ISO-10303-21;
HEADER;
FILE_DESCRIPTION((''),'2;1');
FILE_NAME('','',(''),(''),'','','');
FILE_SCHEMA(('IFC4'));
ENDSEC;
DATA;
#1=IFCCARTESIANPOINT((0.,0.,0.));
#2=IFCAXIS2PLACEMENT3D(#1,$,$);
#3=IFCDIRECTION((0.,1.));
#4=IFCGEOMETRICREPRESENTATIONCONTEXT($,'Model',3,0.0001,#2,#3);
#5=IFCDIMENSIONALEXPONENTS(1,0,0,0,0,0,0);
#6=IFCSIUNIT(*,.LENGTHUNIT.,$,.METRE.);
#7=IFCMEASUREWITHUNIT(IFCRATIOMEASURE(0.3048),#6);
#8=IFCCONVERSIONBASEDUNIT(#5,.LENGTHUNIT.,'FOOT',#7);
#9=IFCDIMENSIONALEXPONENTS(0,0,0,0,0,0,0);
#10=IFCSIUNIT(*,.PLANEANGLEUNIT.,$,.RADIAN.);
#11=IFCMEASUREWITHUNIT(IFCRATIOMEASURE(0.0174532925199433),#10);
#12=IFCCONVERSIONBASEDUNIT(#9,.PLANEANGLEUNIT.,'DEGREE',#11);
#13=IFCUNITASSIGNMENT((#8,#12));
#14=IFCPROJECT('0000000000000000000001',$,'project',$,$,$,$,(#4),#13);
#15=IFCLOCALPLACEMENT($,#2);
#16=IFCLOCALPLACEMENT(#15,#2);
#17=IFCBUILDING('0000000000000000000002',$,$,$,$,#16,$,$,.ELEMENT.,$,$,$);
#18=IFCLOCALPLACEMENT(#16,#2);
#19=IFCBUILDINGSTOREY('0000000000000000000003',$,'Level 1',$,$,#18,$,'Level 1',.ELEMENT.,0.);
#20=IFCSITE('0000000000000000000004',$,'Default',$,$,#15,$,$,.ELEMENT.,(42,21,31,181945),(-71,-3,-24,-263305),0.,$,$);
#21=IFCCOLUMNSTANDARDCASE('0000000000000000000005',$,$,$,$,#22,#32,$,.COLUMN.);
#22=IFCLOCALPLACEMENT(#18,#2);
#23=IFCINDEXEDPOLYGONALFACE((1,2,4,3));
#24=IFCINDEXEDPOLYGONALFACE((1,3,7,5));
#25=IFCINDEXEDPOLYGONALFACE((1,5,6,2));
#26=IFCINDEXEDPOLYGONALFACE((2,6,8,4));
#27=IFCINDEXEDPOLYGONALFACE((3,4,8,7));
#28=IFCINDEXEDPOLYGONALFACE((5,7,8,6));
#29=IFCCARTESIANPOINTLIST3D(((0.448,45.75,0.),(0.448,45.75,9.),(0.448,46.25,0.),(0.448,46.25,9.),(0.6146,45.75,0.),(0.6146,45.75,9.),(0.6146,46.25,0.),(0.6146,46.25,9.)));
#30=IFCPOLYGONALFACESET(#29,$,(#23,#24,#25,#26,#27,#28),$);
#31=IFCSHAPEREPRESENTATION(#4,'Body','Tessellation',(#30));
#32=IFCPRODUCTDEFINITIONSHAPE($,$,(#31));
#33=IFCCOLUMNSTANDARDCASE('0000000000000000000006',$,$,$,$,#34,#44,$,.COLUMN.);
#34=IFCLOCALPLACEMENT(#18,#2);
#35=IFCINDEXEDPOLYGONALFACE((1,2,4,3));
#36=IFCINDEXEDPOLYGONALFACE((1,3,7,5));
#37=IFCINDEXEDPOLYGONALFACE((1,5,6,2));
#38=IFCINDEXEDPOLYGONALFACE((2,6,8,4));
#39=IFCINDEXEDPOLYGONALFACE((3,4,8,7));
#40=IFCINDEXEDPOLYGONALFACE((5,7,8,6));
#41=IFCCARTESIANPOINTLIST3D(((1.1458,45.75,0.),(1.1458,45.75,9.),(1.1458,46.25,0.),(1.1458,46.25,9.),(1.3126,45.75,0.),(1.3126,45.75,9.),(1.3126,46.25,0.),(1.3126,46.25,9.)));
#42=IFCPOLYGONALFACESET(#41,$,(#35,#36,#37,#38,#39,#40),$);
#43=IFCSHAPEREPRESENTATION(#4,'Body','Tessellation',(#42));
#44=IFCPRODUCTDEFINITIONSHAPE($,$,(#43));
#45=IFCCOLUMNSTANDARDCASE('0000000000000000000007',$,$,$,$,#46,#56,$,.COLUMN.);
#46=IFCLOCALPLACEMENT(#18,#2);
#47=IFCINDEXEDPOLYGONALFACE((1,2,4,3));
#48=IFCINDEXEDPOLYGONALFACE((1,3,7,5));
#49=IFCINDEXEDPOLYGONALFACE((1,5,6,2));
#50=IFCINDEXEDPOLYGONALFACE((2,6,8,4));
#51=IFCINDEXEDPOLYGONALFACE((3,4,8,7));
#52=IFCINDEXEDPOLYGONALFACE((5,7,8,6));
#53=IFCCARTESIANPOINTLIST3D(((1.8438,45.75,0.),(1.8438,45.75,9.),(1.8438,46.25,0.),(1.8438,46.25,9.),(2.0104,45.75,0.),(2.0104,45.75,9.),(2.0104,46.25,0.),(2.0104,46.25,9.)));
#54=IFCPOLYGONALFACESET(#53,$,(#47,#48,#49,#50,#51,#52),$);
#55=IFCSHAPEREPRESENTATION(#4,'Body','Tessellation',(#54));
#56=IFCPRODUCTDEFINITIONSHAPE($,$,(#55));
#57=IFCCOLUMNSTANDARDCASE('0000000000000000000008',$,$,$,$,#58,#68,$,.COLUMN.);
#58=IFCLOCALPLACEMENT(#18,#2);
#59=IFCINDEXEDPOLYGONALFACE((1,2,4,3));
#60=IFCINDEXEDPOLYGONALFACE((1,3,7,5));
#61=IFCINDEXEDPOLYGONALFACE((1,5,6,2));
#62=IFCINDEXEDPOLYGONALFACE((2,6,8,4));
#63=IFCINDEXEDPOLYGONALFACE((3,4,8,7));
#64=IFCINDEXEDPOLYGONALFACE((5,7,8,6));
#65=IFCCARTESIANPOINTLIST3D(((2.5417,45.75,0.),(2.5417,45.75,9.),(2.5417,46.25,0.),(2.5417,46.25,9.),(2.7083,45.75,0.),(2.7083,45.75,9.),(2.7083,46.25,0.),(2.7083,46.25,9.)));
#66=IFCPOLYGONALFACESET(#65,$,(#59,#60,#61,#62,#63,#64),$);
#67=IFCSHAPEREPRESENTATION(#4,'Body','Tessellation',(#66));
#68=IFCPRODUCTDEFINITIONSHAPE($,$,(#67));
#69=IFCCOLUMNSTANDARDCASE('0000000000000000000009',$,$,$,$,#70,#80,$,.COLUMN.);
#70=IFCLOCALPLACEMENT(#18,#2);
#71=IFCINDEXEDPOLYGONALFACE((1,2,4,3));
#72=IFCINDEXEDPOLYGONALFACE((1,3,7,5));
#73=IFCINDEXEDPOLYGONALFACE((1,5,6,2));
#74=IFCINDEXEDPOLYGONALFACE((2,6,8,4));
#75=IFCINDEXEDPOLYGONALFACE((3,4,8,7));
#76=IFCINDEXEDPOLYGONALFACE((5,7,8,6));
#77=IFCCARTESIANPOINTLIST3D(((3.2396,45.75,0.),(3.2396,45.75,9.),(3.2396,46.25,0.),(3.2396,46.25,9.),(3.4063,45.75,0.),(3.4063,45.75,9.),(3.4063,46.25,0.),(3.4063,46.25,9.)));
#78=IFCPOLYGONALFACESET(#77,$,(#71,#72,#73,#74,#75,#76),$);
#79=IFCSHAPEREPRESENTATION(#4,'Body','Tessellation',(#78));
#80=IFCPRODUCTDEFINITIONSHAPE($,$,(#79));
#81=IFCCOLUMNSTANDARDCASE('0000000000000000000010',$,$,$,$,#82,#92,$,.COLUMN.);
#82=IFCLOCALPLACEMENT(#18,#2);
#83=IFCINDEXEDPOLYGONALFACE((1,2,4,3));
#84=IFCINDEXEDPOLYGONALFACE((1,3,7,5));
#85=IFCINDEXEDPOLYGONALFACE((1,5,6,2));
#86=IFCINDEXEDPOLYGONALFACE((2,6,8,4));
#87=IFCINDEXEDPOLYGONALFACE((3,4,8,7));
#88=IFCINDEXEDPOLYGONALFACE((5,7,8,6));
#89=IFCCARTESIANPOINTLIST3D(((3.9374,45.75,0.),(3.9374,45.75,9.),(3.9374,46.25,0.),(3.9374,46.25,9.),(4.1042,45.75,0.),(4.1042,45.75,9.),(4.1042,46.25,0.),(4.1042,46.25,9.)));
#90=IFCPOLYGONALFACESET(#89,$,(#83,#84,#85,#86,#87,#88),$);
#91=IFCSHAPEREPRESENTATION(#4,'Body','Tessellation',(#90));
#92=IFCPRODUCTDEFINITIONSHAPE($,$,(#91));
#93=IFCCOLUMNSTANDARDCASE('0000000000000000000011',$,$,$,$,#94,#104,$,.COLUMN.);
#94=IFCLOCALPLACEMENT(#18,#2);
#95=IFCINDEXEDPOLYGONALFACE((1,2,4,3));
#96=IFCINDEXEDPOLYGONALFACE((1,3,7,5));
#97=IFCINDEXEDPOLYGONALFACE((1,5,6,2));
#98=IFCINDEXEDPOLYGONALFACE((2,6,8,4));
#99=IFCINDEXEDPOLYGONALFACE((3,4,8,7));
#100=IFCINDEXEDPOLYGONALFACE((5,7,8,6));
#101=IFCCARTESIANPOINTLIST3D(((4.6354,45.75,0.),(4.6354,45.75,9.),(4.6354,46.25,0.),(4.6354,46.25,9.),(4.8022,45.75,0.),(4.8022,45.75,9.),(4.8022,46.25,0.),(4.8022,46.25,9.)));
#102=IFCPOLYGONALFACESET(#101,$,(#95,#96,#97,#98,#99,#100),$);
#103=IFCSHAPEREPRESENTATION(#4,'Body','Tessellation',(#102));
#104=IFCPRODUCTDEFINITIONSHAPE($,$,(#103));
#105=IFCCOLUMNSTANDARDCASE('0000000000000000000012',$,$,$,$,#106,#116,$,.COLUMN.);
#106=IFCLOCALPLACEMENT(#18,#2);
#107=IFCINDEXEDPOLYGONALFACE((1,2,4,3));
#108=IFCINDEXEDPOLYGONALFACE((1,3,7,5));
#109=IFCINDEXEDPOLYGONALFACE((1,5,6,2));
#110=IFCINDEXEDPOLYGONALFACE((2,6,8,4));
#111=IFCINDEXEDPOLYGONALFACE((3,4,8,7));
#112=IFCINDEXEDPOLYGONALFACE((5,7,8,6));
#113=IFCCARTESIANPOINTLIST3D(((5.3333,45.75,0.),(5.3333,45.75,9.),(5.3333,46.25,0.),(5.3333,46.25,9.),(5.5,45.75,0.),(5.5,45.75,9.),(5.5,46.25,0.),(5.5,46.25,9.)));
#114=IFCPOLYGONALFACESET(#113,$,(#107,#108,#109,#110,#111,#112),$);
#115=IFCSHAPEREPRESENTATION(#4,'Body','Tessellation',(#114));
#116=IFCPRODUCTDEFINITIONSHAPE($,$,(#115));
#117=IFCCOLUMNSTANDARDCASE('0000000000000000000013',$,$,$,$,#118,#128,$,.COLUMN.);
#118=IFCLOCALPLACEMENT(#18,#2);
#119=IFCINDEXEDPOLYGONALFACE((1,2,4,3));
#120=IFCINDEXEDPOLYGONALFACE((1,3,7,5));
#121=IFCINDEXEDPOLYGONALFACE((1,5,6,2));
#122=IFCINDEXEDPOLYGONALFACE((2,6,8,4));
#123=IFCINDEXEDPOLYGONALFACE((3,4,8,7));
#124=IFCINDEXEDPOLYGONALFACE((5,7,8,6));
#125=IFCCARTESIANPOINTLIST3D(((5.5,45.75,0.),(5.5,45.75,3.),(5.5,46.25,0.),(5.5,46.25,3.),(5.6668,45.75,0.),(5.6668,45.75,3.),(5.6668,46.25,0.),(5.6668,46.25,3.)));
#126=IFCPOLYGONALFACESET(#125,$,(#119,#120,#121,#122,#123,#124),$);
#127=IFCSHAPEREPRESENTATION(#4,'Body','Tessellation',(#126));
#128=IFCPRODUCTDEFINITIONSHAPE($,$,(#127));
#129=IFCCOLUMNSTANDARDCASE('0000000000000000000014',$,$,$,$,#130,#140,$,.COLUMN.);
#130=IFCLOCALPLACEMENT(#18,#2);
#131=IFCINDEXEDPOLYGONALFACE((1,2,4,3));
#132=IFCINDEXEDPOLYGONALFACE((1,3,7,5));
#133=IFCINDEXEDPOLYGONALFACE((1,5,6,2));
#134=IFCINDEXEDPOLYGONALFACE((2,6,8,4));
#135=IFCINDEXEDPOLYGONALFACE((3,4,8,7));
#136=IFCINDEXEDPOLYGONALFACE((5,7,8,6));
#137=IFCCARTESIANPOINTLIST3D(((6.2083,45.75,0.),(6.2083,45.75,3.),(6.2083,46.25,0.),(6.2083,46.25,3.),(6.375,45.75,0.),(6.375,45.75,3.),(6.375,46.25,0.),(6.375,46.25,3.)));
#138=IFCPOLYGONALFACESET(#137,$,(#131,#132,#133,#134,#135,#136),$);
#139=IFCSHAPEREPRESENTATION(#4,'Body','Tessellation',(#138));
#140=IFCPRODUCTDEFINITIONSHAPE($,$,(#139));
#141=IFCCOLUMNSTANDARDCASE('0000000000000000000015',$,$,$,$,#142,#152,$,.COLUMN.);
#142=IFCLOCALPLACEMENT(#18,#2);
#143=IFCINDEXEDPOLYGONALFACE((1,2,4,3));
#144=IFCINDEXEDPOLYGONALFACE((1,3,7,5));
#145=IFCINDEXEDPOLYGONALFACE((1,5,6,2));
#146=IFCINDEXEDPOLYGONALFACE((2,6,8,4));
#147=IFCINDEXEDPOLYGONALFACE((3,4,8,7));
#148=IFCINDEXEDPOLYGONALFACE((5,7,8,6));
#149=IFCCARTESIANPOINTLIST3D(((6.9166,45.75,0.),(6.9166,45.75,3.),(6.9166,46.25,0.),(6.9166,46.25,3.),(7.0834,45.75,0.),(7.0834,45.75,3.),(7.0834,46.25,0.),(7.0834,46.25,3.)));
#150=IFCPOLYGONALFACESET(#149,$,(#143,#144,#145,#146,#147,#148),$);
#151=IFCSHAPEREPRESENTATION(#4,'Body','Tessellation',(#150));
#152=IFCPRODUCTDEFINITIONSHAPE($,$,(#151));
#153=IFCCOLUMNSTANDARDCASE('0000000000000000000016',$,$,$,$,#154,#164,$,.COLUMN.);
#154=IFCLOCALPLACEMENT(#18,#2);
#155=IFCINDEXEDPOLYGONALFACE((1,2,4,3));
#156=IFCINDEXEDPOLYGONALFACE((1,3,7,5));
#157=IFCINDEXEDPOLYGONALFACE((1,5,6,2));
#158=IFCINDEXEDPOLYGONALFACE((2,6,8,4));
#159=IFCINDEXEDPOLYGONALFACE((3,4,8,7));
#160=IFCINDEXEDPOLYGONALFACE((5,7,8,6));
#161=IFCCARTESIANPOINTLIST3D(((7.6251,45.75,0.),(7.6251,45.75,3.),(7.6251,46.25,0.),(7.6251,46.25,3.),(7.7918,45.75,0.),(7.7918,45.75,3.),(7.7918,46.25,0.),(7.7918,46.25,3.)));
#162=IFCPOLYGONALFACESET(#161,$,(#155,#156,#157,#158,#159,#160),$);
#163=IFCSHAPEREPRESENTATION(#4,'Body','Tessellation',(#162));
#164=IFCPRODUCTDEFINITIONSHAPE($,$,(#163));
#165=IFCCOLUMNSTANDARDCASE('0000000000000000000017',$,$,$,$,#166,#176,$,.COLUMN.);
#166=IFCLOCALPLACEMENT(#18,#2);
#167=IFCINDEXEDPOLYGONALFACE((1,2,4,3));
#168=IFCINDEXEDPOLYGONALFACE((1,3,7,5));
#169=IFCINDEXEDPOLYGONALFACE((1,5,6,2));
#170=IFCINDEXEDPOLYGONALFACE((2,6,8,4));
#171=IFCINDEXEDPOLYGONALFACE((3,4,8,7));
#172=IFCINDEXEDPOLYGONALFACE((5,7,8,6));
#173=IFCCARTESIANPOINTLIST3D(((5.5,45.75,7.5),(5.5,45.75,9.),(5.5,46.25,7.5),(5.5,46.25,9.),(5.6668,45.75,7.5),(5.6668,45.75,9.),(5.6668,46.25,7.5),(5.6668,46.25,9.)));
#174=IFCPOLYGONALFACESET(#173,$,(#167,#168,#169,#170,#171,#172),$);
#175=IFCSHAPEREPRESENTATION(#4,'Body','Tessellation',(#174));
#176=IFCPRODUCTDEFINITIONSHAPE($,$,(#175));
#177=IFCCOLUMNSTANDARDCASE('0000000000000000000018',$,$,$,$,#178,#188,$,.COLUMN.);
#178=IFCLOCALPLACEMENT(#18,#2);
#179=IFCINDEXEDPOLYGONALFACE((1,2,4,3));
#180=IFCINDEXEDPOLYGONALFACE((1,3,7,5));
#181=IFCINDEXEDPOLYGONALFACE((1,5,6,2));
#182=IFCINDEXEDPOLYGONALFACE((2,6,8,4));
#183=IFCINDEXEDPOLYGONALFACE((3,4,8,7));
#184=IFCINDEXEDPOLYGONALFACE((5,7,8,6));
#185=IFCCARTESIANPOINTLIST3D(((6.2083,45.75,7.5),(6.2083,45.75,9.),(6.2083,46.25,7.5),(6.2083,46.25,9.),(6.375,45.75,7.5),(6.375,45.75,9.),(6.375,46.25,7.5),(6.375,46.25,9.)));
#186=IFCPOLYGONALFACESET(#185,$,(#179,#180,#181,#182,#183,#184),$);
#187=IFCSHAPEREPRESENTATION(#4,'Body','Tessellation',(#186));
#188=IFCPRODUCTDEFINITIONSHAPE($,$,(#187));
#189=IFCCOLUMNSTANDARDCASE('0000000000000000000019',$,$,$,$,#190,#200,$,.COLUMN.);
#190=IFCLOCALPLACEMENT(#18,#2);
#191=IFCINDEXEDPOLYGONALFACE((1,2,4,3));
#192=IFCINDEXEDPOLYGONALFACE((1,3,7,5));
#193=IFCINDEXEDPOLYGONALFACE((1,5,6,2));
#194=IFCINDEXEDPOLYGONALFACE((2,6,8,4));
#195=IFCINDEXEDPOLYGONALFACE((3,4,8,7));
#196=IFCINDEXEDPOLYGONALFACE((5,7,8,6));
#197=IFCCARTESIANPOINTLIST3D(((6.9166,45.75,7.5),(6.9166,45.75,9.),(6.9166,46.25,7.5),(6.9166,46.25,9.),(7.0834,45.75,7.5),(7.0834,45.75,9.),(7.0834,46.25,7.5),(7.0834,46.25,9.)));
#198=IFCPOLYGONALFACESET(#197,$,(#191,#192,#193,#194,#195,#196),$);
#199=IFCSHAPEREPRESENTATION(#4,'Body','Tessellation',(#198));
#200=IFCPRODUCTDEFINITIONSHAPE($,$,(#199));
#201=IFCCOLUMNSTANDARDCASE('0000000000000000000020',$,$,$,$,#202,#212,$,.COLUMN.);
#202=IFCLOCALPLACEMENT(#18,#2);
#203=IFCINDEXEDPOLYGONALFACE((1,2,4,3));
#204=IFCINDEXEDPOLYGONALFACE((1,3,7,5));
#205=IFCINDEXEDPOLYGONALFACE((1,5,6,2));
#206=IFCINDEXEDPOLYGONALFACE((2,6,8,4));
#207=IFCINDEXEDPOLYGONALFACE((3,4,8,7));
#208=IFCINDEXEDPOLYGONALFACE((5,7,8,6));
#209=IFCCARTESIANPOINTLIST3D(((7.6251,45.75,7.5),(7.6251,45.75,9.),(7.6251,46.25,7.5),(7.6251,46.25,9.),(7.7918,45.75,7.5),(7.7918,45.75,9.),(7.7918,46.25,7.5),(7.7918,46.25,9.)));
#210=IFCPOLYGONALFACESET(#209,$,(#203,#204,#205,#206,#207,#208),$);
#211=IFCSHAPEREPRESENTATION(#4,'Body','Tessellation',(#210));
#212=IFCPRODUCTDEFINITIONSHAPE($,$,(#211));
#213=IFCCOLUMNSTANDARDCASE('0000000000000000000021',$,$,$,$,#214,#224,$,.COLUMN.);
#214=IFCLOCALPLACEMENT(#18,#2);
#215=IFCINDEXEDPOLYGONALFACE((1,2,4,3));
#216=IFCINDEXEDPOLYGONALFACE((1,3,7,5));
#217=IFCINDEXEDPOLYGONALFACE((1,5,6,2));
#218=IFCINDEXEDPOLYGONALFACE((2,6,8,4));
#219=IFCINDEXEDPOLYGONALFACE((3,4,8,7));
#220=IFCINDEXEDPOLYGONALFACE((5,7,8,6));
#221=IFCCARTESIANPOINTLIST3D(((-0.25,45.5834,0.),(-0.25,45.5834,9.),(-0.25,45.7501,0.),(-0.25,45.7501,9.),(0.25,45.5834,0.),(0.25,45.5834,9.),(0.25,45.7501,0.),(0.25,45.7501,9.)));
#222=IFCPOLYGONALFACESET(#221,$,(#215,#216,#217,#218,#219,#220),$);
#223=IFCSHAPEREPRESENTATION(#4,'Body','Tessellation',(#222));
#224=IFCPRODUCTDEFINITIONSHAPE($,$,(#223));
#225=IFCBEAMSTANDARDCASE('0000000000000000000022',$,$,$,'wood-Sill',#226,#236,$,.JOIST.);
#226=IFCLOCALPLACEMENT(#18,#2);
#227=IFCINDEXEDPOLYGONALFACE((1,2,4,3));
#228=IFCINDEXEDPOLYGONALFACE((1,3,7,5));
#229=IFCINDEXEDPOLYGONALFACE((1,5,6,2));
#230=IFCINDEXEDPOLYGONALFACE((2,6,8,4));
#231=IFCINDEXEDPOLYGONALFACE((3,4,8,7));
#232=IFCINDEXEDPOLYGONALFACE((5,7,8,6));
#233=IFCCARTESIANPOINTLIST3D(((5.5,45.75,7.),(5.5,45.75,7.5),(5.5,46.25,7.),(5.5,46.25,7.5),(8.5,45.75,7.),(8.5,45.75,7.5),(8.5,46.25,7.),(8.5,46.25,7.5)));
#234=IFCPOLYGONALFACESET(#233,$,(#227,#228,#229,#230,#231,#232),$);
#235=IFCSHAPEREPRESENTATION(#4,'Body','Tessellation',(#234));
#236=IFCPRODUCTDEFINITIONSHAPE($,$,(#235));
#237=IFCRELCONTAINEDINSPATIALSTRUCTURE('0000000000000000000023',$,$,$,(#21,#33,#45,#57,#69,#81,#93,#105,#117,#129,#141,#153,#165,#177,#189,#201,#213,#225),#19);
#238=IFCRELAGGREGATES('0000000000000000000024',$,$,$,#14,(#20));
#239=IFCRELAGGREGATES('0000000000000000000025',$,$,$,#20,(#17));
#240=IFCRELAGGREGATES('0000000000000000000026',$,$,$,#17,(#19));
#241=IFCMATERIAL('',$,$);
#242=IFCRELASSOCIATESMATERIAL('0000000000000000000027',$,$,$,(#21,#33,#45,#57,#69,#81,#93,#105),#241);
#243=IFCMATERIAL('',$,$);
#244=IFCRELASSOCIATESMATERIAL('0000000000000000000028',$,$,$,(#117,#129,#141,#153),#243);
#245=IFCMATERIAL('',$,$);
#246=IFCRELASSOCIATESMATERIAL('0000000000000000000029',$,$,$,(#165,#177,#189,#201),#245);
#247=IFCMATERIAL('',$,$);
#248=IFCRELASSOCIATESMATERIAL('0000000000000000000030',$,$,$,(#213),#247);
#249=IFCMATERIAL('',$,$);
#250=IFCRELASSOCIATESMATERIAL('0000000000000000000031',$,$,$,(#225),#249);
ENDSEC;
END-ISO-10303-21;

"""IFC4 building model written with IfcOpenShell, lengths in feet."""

from ifc_helpers import new_model, entity, si_unit, converted_unit, direction, frame, origin, place, context, project, spatial, rectangle, extrude, material, element, save


model = new_model("IFC4")

# Units and contexts
model_context = context("Model", 3, precision=0.0001, world=origin(), true_north=direction((0.0, 1.0)))
ifc_project = project(units=[converted_unit("LENGTHUNIT", "FOOT", entity("IfcRatioMeasure", 0.3048), si_unit("LENGTHUNIT", "METRE"), dimensions=[1, 0, 0, 0, 0, 0, 0]), converted_unit("PLANEANGLEUNIT", "DEGREE", entity("IfcRatioMeasure", 0.0174532925199433), si_unit("PLANEANGLEUNIT", "RADIAN"), dimensions=[0, 0, 0, 0, 0, 0, 0])], contexts=[model_context])

# Site, building, storey
site_placement = place(None, origin())
site = spatial("IfcSite", under=ifc_project, at=site_placement, Name="Default", CompositionType="ELEMENT", RefLatitude=(42, 21, 31, 181945), RefLongitude=(-71, -3, -24, -263305), RefElevation=0.0)
building_placement = place(site_placement, origin())
building = spatial("IfcBuilding", under=site, at=building_placement, CompositionType="ELEMENT")
storey_placement = place(building_placement, origin())
storey = spatial("IfcBuildingStorey", under=building, at=storey_placement, Name="Level 1", LongName="Level 1", CompositionType="ELEMENT", Elevation=0.0)

# Columns
ifc_material_1 = material(Name="")
placement_1 = place(storey_placement, frame((-0.25, 46.0, 0.0)))
for number, where, z_axis, x_axis in (
    (1, (0.7813, 0.0, 0.0), (0.0, 0.0, 1.0), (1.0, 0.0, 0.0)),
    (2, (1.4792, 0.0, 0.0), (0.0, 0.0, 1.0), (1.0, 0.0, 0.0)),
    (3, (2.1771, 0.0, 0.0), (0.0, 0.0, 1.0), (1.0, 0.0, 0.0)),
    (4, (2.875, 0.0, 0.0), (0.0, 0.0, 1.0), (1.0, 0.0, 0.0)),
    (5, (3.5729, 0.0, 0.0), (0.0, 0.0, 1.0), (1.0, 0.0, 0.0)),
    (6, (4.2708, 0.0, 0.0), (0.0, 0.0, 1.0), (1.0, 0.0, 0.0)),
    (7, (4.9688, 0.0, 0.0), (0.0, 0.0, 1.0), (1.0, 0.0, 0.0)),
    (8, (5.6667, 0.0, 0.0), (0.0, 0.0, 1.0), (1.0, 0.0, 0.0)),
):
    element("IfcColumnStandardCase", number, at=place(placement_1, frame(where, z_axis=z_axis, x_axis=x_axis)), inside=storey, material=ifc_material_1, PredefinedType="COLUMN", context=model_context, shape_type="SweptSolid", body=[
        extrude(rectangle(XDim=0.1667, YDim=0.5), origin(), (0.0, 0.0, 1.0), 9.0),
    ])
ifc_material_2 = material(Name="")
for number, where, z_axis, x_axis in (
    (9, (5.8334, 0.0, 0.0), (0.0, 0.0, 1.0), (1.0, 0.0, 0.0)),
    (10, (6.5417, 0.0, 0.0), (0.0, 0.0, 1.0), (1.0, 0.0, 0.0)),
    (11, (7.25, 0.0, 0.0), (0.0, 0.0, 1.0), (1.0, 0.0, 0.0)),
    (12, (7.9584, 0.0, 0.0), (0.0, 0.0, 1.0), (1.0, 0.0, 0.0)),
):
    element("IfcColumnStandardCase", number, at=place(placement_1, frame(where, z_axis=z_axis, x_axis=x_axis)), inside=storey, material=ifc_material_2, PredefinedType="COLUMN", context=model_context, shape_type="SweptSolid", body=[
        extrude(rectangle(XDim=0.1667, YDim=0.5), origin(), (0.0, 0.0, 1.0), 3.0),
    ])
ifc_material_3 = material(Name="")
for number, where, z_axis, x_axis in (
    (13, (5.8334, 0.0, 7.5), (0.0, 0.0, 1.0), (1.0, 0.0, 0.0)),
    (14, (6.5417, 0.0, 7.5), (0.0, 0.0, 1.0), (1.0, 0.0, 0.0)),
    (15, (7.25, 0.0, 7.5), (0.0, 0.0, 1.0), (1.0, 0.0, 0.0)),
    (16, (7.9584, 0.0, 7.5), (0.0, 0.0, 1.0), (1.0, 0.0, 0.0)),
):
    element("IfcColumnStandardCase", number, at=place(placement_1, frame(where, z_axis=z_axis, x_axis=x_axis)), inside=storey, material=ifc_material_3, PredefinedType="COLUMN", context=model_context, shape_type="SweptSolid", body=[
        extrude(rectangle(XDim=0.1667, YDim=0.5), origin(), (0.0, 0.0, 1.0), 1.5),
    ])
ifc_material_4 = material(Name="")
placement_2 = place(storey_placement, frame((0.0, -0.25, 0.0), z_axis=(0.0, 0.0, 1.0), x_axis=(0.0, 1.0, 0.0)))
column_placement = place(placement_2, frame((45.9167, 0.0, 0.0), z_axis=(0.0, 0.0, 1.0), x_axis=(1.0, 0.0, 0.0)))
element("IfcColumnStandardCase", 17, at=column_placement, inside=storey, material=ifc_material_4, PredefinedType="COLUMN", context=model_context, shape_type="SweptSolid", body=[
    extrude(rectangle(XDim=0.1667, YDim=0.5), origin(), (0.0, 0.0, 1.0), 9.0),
])

# Beam
ifc_material_5 = material(Name="")
for number, where, z_axis, x_axis in (
    (18, (7.25, 0.0, 7.0), (0.0, 0.0, 1.0), (1.0, 0.0, 0.0)),
):
    element("IfcBeamStandardCase", number, at=place(placement_1, frame(where, z_axis=z_axis, x_axis=x_axis)), inside=storey, material=ifc_material_5, ObjectType="wood-Sill", PredefinedType="JOIST", context=model_context, shape_type="SweptSolid", body=[
        extrude(rectangle(XDim=3.0, YDim=0.5), origin(), (0.0, 0.0, 1.0), 0.5),
    ])

save(model, "model.ifc")
